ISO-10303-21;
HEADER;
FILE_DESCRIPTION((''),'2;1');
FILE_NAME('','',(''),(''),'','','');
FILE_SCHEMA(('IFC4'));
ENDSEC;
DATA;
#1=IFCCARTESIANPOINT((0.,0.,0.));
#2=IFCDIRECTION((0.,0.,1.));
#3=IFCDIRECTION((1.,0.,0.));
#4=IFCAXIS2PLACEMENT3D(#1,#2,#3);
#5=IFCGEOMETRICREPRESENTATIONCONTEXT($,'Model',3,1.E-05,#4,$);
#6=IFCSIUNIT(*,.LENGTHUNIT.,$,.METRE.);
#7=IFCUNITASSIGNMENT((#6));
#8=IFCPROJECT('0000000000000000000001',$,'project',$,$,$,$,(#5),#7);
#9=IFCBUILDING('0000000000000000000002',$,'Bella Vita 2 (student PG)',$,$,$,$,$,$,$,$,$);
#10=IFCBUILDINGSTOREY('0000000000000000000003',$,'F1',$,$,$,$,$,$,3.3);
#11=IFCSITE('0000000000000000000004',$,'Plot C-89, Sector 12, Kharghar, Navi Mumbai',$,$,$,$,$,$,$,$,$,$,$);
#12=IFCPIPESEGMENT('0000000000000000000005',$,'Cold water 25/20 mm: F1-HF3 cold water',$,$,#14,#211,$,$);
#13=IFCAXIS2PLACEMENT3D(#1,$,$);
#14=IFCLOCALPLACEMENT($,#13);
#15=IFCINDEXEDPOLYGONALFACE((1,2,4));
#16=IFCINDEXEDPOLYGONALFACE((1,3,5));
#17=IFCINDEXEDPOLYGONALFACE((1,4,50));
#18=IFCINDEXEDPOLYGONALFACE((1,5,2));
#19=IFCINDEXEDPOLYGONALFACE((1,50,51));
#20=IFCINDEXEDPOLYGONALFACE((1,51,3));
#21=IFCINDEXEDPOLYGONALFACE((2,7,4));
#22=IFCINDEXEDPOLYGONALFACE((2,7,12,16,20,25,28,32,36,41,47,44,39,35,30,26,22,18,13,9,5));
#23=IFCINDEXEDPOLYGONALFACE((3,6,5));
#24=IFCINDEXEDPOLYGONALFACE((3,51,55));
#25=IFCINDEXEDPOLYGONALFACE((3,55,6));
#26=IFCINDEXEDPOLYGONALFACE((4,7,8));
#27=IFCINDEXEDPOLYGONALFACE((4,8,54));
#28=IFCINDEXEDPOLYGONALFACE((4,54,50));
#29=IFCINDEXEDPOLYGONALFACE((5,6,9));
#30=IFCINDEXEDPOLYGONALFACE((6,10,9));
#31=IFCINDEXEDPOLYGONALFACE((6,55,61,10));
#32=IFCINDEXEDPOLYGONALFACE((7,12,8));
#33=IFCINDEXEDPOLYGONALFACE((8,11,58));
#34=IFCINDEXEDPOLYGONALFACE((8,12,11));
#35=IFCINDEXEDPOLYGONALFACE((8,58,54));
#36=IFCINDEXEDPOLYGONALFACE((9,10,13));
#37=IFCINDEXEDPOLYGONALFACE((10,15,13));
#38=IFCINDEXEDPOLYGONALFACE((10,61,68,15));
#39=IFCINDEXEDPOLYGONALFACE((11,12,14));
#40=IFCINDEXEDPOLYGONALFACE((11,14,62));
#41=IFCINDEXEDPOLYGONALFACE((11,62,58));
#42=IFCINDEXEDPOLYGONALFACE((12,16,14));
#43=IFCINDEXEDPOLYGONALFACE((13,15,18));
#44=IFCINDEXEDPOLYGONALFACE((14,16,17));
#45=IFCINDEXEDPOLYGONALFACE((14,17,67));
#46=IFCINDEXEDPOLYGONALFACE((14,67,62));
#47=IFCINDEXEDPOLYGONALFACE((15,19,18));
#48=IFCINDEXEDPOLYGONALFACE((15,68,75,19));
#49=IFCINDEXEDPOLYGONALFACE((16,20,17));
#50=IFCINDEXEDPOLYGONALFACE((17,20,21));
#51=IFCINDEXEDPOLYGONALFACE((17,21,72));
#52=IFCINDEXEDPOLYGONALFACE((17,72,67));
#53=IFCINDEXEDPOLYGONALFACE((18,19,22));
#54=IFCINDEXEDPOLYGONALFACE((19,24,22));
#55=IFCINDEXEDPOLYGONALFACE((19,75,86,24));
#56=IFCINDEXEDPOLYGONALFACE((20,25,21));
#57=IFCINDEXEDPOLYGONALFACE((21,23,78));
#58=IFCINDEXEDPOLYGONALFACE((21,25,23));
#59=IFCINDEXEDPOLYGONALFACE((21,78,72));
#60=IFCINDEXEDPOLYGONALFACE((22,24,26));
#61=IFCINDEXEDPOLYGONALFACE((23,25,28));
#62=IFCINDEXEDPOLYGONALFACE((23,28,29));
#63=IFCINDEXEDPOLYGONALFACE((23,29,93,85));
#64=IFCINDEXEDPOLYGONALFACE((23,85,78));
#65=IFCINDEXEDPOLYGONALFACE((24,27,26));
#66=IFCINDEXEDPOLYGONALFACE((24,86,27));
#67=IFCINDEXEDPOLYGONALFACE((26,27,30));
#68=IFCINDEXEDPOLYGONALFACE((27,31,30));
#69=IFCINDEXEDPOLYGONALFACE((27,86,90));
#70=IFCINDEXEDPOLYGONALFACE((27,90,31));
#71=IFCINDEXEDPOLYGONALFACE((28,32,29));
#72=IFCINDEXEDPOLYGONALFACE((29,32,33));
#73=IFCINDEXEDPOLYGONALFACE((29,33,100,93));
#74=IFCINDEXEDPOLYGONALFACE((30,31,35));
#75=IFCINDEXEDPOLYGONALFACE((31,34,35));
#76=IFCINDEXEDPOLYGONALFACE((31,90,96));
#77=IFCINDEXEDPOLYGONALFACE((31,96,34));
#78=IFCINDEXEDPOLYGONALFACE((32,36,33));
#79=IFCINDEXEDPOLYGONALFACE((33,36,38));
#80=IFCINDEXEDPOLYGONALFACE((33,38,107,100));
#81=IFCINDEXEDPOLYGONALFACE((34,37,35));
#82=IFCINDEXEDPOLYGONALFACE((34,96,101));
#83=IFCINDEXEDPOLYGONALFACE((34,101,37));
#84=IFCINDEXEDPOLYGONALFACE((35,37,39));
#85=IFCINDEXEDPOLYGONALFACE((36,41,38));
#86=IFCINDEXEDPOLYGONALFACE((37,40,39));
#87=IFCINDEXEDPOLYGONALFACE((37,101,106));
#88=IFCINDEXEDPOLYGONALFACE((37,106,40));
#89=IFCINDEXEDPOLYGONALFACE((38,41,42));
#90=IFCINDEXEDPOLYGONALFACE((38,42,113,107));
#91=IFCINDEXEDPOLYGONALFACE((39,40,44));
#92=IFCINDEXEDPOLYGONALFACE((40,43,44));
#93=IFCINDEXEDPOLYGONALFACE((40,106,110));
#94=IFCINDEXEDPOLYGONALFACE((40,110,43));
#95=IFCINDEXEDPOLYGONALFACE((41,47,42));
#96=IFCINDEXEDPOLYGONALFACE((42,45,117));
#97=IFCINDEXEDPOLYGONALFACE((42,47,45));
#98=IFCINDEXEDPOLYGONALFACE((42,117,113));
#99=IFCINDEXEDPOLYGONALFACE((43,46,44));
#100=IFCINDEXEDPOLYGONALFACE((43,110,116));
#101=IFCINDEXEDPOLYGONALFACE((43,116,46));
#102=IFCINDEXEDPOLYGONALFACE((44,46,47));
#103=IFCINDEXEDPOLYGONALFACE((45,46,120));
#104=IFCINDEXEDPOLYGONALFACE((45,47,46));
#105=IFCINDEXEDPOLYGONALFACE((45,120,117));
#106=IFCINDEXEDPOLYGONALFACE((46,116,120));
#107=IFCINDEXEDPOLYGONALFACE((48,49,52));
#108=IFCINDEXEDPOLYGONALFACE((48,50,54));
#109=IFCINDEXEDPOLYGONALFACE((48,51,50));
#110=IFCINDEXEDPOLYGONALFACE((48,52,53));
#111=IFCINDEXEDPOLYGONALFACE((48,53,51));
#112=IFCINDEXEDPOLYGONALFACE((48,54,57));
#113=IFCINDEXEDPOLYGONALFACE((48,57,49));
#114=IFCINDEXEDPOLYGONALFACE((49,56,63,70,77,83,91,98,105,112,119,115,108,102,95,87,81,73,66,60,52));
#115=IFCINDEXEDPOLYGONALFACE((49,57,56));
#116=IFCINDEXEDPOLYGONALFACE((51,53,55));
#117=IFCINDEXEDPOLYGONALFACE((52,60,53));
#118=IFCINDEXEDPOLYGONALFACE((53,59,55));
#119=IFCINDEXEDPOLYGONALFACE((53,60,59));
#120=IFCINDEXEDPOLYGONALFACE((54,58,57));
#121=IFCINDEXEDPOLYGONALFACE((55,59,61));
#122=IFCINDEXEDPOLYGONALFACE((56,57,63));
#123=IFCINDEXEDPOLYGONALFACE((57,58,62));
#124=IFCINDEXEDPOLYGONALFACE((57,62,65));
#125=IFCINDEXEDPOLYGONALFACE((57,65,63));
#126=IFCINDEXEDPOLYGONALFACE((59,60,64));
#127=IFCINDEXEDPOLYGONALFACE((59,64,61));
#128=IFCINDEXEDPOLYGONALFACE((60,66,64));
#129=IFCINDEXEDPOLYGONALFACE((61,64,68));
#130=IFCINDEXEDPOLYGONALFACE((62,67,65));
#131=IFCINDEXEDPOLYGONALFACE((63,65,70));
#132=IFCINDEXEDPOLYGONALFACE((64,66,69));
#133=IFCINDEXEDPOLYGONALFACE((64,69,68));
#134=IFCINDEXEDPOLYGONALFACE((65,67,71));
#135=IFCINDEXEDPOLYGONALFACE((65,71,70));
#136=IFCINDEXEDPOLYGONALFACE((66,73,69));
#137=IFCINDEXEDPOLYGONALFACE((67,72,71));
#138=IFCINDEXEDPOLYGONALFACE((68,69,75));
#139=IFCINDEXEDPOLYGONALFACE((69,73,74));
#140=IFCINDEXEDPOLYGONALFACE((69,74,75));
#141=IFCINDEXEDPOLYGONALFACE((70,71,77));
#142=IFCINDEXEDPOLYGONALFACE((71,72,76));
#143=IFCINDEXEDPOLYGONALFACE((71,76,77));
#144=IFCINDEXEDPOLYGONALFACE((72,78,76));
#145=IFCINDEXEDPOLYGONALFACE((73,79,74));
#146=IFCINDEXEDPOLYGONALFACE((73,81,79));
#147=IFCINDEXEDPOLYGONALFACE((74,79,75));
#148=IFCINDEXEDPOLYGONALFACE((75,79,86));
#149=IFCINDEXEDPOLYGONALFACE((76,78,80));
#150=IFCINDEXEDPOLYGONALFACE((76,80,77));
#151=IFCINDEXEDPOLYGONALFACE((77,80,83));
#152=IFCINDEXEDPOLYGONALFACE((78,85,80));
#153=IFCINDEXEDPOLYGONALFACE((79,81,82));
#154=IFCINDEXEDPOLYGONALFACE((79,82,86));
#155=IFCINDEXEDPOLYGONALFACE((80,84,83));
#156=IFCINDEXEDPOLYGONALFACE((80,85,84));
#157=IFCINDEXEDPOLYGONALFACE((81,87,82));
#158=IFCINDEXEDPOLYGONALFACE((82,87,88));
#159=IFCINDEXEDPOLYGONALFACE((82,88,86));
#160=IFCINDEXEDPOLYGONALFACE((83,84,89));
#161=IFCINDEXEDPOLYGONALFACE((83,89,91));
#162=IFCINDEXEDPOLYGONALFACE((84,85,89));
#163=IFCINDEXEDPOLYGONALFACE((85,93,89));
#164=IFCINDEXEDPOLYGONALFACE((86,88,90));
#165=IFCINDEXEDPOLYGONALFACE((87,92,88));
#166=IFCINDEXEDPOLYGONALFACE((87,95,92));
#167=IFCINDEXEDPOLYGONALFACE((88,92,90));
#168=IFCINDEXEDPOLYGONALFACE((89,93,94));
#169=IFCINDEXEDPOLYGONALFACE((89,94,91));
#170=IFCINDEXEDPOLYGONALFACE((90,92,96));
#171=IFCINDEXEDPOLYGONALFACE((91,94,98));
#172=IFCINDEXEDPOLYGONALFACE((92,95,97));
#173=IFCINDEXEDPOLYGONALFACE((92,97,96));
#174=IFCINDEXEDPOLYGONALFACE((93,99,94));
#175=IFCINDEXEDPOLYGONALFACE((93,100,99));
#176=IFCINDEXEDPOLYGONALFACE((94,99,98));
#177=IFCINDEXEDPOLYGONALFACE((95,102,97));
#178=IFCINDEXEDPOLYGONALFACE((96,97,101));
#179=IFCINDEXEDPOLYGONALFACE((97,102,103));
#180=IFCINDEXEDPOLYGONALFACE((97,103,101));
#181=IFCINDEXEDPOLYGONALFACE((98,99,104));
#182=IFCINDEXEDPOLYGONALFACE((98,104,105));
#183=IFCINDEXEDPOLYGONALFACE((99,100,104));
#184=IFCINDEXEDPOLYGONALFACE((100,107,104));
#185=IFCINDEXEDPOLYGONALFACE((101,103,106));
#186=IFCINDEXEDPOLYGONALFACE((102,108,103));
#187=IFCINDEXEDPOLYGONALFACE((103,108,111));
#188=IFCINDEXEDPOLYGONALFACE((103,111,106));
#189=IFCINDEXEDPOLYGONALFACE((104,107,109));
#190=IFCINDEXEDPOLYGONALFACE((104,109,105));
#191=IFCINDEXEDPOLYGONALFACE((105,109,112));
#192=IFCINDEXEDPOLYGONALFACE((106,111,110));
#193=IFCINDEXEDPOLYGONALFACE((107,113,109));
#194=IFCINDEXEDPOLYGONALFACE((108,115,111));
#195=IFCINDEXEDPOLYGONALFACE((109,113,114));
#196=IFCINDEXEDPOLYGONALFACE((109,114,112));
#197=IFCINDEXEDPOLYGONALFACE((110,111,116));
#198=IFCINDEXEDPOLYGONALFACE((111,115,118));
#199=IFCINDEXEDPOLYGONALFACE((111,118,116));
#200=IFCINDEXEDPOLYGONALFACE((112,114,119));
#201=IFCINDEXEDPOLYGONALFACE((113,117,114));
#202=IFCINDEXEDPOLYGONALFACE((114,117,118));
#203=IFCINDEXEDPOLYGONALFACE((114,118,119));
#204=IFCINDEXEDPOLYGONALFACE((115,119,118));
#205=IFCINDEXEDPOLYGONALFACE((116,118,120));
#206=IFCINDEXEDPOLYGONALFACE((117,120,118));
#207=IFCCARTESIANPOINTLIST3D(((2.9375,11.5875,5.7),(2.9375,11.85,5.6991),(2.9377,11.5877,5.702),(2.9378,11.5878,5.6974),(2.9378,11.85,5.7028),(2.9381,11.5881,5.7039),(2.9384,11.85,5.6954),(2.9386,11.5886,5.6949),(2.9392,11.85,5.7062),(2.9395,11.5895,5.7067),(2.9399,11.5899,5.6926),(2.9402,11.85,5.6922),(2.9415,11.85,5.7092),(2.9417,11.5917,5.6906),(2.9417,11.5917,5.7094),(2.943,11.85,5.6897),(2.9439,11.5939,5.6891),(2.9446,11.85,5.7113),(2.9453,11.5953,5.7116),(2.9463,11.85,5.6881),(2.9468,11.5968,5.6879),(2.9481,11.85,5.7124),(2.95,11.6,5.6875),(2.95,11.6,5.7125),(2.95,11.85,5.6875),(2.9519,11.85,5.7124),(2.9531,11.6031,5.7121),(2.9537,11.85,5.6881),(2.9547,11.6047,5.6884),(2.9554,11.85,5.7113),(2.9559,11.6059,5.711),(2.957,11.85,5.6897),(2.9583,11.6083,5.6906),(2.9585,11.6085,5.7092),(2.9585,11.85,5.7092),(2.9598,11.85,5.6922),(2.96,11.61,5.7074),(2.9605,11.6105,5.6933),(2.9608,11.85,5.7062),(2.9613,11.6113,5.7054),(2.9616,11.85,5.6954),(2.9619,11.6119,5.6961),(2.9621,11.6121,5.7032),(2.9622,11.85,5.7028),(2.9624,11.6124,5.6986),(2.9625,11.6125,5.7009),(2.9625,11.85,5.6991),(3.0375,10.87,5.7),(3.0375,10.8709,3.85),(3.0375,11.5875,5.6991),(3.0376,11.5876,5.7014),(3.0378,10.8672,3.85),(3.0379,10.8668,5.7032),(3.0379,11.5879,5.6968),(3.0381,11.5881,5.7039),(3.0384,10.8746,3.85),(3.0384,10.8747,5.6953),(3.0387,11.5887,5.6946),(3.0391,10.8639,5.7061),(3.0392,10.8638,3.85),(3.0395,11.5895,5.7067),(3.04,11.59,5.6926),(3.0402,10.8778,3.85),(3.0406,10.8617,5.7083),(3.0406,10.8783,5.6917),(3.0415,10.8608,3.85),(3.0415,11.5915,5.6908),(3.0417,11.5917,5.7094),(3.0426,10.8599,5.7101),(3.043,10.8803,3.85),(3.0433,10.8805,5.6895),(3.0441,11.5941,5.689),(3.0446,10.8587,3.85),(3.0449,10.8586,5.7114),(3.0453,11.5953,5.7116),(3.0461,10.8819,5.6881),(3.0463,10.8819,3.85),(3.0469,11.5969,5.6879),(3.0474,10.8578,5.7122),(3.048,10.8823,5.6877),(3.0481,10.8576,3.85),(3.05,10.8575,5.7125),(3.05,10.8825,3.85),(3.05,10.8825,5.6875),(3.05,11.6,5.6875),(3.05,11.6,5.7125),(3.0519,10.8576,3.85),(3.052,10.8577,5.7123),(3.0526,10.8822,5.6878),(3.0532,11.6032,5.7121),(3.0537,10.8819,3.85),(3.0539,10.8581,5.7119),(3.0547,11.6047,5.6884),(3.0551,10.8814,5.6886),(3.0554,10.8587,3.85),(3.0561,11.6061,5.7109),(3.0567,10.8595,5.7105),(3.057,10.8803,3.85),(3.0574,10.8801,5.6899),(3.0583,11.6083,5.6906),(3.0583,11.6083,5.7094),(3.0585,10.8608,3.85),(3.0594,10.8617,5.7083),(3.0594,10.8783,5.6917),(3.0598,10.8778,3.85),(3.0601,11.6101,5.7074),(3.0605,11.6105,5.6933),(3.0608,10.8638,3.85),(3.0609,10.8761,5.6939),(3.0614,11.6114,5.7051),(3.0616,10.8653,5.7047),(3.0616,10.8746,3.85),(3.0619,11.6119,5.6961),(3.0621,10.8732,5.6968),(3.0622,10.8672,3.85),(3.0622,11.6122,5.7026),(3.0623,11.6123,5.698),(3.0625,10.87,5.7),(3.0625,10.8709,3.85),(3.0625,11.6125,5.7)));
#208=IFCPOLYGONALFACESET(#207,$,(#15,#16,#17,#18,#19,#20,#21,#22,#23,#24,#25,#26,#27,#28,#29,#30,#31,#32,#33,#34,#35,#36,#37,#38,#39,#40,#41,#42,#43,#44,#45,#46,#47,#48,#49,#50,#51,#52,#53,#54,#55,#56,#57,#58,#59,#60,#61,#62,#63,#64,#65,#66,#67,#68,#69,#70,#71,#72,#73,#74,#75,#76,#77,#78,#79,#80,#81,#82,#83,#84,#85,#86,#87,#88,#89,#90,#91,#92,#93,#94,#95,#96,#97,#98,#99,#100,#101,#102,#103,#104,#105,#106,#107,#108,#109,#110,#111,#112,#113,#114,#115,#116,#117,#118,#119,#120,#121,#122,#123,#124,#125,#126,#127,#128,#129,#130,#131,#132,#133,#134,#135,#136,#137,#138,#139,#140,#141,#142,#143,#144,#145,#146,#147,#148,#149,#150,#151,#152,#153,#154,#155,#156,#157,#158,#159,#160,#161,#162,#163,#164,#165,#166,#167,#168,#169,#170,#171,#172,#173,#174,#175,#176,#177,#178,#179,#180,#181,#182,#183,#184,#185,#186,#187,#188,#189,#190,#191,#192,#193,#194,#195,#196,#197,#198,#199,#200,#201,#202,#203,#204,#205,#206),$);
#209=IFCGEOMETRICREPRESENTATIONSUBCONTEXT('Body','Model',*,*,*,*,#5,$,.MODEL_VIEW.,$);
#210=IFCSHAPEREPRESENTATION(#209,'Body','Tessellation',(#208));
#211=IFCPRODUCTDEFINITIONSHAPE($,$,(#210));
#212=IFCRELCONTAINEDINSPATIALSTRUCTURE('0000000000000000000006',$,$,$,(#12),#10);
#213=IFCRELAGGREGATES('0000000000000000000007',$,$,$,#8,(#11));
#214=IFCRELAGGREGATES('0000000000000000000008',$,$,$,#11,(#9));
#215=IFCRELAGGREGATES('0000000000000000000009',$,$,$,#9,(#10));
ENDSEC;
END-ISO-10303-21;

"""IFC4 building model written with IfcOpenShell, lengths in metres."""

from ifc_helpers import new_model, entity, si_unit, origin, origin_with_axes, place, context, subcontext, project, spatial, element, save


model = new_model("IFC4")

# Units and contexts
model_context = context("Model", 3, precision=1e-05, world=origin_with_axes())
body_context = subcontext(model_context, "Body", "Model", "MODEL_VIEW")
ifc_project = project(units=[si_unit("LENGTHUNIT", "METRE")], contexts=[model_context])

# Site, building, storey
site = spatial("IfcSite", under=ifc_project, Name="Plot C-89, Sector 12, Kharghar, Navi Mumbai")
building = spatial("IfcBuilding", under=site, Name="Bella Vita 2 (student PG)")
storey = spatial("IfcBuildingStorey", under=building, Name="F1", Elevation=3.3)

# Pipe segment
pipe_segment_1_placement = place(None, origin())
element("IfcPipeSegment", 1, at=pipe_segment_1_placement, inside=storey, Name="Cold water 25/20 mm: F1-HF3 cold water", context=body_context, shape_type="AdvancedSweptSolid", body=[
    entity("IfcSweptDiskSolid", entity("IfcPolyline", [entity("IfcCartesianPoint", [2.95, 11.85, 5.7]), entity("IfcCartesianPoint", [2.95, 11.6, 5.7]), entity("IfcCartesianPoint", [3.05, 11.6, 5.7]), entity("IfcCartesianPoint", [3.05, 10.87, 5.7]), entity("IfcCartesianPoint", [3.05, 10.87, 3.85])]), 0.0125),
])

save(model, "model.ifc")
